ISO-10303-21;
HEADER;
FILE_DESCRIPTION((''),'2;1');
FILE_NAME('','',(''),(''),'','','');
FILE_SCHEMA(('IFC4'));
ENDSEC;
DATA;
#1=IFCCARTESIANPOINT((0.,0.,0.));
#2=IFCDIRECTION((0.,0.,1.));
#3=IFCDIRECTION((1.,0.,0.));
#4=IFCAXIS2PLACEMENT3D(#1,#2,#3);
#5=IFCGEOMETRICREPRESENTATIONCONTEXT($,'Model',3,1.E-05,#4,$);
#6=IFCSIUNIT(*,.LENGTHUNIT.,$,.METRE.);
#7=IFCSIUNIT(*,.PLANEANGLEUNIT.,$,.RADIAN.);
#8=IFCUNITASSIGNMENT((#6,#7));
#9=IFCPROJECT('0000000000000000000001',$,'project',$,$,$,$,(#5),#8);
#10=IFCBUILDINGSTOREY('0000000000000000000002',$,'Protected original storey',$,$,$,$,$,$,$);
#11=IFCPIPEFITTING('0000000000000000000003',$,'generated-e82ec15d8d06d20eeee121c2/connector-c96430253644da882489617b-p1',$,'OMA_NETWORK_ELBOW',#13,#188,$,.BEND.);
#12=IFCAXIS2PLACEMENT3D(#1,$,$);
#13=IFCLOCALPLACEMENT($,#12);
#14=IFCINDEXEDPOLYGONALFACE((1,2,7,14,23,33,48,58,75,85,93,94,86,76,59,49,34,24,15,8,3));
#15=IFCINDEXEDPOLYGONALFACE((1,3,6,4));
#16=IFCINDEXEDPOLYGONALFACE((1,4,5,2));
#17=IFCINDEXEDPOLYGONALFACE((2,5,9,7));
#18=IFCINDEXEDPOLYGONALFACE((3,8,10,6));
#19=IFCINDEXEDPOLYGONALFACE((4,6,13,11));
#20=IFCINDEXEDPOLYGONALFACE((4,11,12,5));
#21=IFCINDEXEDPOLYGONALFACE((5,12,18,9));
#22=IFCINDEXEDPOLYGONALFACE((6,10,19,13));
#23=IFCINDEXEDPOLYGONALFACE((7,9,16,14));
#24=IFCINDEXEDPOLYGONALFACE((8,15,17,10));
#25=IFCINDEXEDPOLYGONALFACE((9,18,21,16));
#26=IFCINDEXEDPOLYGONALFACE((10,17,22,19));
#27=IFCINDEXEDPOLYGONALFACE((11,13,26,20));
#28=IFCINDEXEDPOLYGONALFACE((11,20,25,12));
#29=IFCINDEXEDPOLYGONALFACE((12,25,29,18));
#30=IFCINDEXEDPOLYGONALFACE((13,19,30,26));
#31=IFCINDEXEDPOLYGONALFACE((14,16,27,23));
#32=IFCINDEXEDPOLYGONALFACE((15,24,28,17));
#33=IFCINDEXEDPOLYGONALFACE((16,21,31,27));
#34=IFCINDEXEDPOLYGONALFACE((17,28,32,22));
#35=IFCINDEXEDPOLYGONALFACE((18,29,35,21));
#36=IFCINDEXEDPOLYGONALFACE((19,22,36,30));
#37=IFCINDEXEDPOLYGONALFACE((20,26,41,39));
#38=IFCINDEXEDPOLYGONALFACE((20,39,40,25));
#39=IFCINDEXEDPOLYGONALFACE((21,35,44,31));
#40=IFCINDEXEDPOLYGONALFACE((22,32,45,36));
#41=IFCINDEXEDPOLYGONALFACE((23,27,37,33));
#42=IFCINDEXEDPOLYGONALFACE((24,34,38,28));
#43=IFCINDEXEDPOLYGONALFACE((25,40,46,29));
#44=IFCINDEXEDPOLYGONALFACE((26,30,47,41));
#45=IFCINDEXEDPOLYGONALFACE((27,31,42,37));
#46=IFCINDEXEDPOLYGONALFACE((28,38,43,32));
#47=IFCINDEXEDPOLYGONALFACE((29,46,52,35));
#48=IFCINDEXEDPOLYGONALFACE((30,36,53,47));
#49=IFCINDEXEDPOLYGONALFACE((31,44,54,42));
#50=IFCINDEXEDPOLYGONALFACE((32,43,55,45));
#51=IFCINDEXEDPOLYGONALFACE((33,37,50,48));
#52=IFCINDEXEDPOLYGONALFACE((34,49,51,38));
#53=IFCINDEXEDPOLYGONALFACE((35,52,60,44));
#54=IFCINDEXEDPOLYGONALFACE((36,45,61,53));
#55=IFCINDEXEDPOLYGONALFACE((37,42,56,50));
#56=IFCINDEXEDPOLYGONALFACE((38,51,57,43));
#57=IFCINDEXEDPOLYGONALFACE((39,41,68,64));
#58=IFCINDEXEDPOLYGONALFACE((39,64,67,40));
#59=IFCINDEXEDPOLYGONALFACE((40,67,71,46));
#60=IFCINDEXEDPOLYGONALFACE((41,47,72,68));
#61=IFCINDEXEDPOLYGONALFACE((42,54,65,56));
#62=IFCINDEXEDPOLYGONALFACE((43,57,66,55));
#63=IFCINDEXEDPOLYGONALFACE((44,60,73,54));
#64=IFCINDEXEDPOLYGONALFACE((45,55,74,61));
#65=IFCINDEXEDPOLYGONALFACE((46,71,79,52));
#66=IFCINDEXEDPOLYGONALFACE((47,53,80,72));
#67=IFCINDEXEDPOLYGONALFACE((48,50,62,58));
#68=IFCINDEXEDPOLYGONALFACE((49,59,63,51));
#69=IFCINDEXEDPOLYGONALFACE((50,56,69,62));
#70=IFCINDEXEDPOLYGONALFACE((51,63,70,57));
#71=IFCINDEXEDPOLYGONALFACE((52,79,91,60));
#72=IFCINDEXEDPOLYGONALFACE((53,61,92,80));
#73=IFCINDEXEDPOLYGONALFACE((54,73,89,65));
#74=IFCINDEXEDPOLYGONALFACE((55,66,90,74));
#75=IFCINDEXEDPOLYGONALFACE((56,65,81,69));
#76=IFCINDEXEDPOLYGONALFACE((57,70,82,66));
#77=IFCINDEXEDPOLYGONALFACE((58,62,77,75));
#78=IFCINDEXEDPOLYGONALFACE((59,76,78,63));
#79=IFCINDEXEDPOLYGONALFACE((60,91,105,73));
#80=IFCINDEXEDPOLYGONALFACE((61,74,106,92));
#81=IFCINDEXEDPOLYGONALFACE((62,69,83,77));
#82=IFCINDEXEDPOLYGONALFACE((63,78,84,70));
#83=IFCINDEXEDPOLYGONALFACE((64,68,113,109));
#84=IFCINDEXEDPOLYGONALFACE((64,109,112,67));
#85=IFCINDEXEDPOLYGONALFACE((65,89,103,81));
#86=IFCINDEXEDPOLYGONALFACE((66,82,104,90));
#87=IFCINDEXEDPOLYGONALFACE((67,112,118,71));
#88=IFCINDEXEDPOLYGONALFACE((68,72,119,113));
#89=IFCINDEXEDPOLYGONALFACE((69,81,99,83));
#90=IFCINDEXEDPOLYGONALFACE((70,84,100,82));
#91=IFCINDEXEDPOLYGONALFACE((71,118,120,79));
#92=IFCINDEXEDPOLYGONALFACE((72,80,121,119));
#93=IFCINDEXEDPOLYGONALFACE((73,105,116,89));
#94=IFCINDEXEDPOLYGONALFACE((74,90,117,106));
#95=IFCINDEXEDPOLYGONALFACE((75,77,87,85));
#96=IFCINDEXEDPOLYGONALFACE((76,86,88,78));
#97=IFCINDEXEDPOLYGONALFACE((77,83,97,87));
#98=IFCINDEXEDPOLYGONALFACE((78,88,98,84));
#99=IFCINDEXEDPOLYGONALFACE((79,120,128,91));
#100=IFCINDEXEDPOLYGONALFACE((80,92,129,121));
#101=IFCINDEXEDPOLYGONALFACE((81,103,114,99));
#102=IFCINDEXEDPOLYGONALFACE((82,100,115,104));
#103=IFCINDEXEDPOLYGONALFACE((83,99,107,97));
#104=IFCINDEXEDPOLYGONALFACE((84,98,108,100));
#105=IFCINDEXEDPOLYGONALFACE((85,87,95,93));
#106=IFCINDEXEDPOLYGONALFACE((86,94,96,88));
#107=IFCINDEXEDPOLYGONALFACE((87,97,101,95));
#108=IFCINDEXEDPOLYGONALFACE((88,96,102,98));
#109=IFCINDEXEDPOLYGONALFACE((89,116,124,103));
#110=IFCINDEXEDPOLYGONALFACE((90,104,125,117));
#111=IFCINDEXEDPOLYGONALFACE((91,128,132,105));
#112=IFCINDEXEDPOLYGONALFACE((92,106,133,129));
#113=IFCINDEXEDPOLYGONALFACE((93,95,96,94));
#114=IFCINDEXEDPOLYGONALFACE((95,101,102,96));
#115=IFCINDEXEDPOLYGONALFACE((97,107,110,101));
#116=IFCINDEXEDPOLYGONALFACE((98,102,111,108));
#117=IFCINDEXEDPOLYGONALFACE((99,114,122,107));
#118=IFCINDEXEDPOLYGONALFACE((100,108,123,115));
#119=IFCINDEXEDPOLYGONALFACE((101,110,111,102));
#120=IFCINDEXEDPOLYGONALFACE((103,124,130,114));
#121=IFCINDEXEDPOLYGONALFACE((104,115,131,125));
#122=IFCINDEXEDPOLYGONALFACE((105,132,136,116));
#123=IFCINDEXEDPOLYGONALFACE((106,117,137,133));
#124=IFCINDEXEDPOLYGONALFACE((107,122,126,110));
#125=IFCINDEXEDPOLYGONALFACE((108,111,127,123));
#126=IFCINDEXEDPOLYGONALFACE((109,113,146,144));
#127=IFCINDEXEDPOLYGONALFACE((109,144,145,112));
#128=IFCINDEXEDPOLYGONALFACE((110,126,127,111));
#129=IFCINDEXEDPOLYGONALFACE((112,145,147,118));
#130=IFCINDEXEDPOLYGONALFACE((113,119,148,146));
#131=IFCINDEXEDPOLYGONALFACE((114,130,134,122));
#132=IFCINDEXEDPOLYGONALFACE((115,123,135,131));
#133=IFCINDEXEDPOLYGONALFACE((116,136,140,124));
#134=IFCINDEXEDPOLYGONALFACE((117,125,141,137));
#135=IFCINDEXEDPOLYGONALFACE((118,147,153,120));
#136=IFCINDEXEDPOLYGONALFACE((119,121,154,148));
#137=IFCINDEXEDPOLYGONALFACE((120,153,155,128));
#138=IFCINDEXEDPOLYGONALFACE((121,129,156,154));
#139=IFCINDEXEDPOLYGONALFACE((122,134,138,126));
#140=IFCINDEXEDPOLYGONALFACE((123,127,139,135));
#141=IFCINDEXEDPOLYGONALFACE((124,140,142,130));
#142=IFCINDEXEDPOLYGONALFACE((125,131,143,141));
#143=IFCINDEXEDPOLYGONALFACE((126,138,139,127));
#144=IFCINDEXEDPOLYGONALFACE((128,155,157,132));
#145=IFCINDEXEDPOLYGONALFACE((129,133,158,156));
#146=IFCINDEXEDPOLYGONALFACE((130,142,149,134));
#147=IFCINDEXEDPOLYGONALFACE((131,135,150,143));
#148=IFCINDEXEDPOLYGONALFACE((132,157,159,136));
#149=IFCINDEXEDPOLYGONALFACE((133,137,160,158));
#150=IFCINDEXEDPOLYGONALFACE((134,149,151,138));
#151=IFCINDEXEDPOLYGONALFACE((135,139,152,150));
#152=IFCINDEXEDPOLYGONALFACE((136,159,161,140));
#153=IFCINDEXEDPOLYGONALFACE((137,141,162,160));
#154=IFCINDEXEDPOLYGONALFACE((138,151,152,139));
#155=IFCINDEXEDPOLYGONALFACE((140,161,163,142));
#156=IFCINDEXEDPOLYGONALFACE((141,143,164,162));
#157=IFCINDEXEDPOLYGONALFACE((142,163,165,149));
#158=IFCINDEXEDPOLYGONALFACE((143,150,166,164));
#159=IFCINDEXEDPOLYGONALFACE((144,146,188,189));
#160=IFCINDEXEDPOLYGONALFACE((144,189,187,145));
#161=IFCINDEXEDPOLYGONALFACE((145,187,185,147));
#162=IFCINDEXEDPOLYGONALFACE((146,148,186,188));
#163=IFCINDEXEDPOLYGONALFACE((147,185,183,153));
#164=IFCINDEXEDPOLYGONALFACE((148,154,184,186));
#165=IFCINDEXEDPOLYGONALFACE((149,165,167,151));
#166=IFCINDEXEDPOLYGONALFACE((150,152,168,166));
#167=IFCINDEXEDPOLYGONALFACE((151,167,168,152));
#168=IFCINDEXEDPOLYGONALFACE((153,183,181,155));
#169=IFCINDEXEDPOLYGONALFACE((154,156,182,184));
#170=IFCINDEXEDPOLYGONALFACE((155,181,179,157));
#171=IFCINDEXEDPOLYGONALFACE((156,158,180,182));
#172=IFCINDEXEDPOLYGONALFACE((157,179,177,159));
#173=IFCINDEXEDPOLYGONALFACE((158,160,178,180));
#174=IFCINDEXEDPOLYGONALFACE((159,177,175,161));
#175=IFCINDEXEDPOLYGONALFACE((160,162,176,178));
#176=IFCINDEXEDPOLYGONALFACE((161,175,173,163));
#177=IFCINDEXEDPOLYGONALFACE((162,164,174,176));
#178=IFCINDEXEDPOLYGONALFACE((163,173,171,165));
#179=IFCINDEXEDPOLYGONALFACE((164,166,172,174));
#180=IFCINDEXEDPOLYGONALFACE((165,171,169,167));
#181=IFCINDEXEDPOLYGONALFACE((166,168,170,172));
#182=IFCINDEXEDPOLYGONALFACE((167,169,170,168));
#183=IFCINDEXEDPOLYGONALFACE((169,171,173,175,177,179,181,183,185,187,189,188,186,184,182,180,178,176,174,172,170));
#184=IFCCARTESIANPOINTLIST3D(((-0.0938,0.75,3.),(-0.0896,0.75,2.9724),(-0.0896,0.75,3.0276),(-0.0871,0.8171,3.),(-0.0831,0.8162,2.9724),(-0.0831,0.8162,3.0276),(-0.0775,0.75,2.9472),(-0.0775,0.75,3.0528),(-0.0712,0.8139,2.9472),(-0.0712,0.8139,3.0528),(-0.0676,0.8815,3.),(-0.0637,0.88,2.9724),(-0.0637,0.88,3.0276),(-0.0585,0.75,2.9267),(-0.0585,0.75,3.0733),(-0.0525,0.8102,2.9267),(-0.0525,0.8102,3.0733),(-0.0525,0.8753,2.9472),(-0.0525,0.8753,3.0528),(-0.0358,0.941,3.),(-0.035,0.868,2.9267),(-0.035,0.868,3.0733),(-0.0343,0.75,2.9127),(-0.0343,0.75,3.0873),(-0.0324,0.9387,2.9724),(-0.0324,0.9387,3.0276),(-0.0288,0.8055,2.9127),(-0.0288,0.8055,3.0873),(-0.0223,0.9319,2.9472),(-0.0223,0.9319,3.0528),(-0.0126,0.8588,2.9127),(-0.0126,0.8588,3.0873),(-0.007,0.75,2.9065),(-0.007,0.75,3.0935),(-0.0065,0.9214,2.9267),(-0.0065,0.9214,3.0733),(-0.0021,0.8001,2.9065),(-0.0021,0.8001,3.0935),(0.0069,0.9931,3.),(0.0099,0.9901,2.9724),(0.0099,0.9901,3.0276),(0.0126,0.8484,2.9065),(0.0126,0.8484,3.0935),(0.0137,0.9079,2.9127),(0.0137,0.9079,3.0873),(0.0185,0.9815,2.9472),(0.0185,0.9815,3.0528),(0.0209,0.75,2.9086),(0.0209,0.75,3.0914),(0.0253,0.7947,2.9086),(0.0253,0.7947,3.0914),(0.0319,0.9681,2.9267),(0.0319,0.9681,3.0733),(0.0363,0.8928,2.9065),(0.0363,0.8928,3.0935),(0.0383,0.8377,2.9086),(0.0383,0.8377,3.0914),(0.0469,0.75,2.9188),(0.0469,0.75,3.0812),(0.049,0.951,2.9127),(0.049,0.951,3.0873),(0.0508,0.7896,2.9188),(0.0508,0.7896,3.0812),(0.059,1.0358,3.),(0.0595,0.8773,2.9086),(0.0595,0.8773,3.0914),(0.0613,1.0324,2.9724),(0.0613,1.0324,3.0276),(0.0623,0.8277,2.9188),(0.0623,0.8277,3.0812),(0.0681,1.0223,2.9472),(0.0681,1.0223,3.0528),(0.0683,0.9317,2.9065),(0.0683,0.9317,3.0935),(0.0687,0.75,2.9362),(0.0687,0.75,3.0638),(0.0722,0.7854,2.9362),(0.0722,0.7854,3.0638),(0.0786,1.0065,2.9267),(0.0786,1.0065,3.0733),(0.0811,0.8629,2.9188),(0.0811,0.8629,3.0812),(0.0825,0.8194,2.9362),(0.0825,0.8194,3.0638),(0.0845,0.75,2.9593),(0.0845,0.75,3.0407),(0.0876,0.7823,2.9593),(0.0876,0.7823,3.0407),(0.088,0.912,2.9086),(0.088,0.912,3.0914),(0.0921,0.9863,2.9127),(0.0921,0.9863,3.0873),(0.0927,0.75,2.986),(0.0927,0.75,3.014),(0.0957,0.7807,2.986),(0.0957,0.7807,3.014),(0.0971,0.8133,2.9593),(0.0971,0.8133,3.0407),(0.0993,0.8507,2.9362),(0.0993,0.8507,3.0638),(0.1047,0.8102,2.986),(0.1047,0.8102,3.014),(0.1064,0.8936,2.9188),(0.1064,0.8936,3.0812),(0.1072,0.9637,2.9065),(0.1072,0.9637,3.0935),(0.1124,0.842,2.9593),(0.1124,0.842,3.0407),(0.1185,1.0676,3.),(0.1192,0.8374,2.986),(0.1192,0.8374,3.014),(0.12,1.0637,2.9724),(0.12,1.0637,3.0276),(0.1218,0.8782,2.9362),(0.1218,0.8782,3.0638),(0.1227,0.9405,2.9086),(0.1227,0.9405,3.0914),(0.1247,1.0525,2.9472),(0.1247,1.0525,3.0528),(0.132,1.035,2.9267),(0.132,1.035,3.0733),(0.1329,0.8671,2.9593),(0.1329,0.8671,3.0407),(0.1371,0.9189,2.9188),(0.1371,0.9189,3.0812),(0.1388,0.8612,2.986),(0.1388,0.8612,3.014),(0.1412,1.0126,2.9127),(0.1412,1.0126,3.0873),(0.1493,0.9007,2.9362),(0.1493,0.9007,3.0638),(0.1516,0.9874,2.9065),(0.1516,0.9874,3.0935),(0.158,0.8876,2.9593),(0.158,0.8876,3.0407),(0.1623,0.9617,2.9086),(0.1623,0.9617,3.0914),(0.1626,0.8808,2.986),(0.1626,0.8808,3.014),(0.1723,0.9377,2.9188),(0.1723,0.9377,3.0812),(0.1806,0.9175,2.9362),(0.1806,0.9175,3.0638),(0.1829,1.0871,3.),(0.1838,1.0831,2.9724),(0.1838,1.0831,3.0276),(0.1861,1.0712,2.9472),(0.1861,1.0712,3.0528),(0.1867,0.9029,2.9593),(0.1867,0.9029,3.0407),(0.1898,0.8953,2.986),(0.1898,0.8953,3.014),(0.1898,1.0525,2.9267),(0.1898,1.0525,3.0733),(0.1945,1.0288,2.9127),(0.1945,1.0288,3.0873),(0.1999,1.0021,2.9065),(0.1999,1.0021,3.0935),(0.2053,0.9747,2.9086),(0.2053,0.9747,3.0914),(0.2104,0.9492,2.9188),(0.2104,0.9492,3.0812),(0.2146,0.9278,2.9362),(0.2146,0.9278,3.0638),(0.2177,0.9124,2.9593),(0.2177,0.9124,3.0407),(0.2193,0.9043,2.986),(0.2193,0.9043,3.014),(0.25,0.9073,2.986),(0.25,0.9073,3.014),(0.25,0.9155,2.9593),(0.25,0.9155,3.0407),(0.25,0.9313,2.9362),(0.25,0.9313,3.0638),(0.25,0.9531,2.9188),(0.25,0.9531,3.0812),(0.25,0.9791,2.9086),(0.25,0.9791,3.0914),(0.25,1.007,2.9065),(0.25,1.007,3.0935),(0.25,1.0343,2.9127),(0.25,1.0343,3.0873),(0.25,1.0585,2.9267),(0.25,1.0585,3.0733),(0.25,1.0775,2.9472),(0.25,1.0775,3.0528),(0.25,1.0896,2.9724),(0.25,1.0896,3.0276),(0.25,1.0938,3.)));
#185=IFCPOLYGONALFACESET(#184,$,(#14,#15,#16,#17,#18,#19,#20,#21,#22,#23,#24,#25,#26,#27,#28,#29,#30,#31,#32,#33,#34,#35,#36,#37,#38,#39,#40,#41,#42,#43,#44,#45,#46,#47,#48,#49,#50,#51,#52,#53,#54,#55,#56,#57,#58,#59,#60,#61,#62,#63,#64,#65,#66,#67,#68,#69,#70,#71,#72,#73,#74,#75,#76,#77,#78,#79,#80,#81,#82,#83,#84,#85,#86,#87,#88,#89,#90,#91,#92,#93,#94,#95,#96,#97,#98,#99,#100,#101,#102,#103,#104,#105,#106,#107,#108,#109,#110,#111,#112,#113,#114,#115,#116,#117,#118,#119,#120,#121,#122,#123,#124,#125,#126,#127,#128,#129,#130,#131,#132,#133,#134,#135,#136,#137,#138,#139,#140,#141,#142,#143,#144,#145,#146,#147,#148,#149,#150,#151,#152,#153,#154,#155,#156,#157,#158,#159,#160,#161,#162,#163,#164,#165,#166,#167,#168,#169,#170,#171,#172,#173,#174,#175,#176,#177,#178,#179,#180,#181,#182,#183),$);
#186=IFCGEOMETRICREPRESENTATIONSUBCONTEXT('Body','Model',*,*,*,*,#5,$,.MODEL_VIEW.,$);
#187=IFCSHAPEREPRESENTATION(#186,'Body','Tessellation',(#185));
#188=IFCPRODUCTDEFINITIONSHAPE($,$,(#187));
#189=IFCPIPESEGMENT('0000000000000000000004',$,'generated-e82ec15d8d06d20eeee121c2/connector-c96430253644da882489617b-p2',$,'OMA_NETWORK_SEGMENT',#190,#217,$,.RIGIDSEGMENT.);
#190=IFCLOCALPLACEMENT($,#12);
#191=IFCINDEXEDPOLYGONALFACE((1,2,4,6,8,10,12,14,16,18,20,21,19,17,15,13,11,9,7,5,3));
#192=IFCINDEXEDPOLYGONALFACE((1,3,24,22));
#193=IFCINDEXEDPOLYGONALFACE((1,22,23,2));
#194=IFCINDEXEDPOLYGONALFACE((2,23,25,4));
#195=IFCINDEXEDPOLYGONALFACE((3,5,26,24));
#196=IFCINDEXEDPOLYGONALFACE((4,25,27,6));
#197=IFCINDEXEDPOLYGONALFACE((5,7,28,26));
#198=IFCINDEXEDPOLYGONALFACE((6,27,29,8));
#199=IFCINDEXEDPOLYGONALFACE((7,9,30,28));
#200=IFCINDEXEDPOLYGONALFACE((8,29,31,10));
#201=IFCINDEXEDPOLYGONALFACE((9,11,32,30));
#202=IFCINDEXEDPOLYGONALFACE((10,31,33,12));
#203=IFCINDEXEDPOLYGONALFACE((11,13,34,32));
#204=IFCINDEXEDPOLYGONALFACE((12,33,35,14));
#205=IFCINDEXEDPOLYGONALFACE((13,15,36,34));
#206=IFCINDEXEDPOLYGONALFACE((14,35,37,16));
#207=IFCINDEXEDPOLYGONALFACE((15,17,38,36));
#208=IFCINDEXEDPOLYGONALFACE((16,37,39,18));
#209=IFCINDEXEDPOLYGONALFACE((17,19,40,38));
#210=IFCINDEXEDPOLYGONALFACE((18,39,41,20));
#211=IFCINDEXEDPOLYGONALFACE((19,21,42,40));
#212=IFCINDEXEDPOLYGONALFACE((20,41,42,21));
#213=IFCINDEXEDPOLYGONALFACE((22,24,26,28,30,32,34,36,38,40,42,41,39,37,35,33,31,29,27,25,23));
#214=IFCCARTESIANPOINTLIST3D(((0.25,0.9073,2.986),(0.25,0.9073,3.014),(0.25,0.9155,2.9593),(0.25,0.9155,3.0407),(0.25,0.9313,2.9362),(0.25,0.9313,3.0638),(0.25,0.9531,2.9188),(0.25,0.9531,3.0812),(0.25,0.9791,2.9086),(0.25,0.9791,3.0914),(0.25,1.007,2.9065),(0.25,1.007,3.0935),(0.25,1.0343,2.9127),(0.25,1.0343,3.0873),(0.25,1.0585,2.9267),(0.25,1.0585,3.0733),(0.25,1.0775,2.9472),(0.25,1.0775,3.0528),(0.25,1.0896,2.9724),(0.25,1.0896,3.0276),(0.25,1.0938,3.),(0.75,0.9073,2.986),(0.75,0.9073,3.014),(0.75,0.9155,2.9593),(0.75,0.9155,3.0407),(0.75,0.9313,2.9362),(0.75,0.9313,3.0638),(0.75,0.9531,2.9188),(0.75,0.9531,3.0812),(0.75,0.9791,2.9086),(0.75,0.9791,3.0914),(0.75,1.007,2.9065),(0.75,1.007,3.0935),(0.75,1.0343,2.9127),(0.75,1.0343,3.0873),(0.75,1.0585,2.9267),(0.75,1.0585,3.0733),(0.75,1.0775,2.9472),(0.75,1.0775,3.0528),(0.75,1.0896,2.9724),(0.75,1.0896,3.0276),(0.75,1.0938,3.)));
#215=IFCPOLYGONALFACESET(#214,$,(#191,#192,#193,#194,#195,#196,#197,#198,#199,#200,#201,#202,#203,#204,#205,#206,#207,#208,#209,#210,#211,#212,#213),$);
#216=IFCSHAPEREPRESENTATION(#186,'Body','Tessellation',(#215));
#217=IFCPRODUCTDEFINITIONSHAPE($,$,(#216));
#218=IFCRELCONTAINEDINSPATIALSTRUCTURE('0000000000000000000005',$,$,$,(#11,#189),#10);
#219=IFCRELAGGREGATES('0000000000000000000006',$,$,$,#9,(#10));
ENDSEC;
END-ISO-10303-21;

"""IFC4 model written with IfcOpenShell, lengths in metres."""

from ifc_helpers import new_model, entity, si_unit, frame, origin_with_axes, origin_2d, place, context, subcontext, project, spatial, circle, extrude, element, save


model = new_model("IFC4")

# Units and contexts
model_context = context("Model", 3, precision=1e-05, world=origin_with_axes())
body_context = subcontext(model_context, "Body", "Model", "MODEL_VIEW")
ifc_project = project(units=[si_unit("LENGTHUNIT", "METRE"), si_unit("PLANEANGLEUNIT", "RADIAN")], contexts=[model_context])

# Storey
storey = spatial("IfcBuildingStorey", under=ifc_project, Name="Protected original storey")

# Pipe fitting
pipe_fitting_1_placement = place(None, origin_with_axes())
element("IfcPipeFitting", 1, at=pipe_fitting_1_placement, inside=storey, Name="generated-e82ec15d8d06d20eeee121c2/connector-c96430253644da882489617b-p1", ObjectType="OMA_NETWORK_ELBOW", PredefinedType="BEND", context=body_context, shape_type="SweptSolid", body=[
    entity("IfcRevolvedAreaSolid", entity("IfcCircleProfileDef", "AREA", None, entity("IfcAxis2Placement2D", entity("IfcCartesianPoint", [0.25, 0.0])), 0.0938), entity("IfcAxis2Placement3D", entity("IfcCartesianPoint", [0.25, 0.75, 3.0]), entity("IfcDirection", [0.0, 1.0, 0.0]), entity("IfcDirection", [-1.0, 0.0, 0.0])), entity("IfcAxis1Placement", entity("IfcCartesianPoint", [0.0, 0.0, 0.0]), entity("IfcDirection", [0.0, -1.0, 0.0])), 1.570796),
])

# Pipe segment
pipe_segment_1_placement = place(None, origin_with_axes())
element("IfcPipeSegment", 2, at=pipe_segment_1_placement, inside=storey, Name="generated-e82ec15d8d06d20eeee121c2/connector-c96430253644da882489617b-p2", ObjectType="OMA_NETWORK_SEGMENT", PredefinedType="RIGIDSEGMENT", context=body_context, shape_type="SweptSolid", body=[
    extrude(circle(Radius=0.0938, at=origin_2d()), frame((0.25, 1.0, 3.0), z_axis=(1.0, 0.0, 0.0), x_axis=(0.0, 1.0, 0.0)), (0.0, 0.0, 1.0), 0.5),
])

save(model, "model.ifc")
